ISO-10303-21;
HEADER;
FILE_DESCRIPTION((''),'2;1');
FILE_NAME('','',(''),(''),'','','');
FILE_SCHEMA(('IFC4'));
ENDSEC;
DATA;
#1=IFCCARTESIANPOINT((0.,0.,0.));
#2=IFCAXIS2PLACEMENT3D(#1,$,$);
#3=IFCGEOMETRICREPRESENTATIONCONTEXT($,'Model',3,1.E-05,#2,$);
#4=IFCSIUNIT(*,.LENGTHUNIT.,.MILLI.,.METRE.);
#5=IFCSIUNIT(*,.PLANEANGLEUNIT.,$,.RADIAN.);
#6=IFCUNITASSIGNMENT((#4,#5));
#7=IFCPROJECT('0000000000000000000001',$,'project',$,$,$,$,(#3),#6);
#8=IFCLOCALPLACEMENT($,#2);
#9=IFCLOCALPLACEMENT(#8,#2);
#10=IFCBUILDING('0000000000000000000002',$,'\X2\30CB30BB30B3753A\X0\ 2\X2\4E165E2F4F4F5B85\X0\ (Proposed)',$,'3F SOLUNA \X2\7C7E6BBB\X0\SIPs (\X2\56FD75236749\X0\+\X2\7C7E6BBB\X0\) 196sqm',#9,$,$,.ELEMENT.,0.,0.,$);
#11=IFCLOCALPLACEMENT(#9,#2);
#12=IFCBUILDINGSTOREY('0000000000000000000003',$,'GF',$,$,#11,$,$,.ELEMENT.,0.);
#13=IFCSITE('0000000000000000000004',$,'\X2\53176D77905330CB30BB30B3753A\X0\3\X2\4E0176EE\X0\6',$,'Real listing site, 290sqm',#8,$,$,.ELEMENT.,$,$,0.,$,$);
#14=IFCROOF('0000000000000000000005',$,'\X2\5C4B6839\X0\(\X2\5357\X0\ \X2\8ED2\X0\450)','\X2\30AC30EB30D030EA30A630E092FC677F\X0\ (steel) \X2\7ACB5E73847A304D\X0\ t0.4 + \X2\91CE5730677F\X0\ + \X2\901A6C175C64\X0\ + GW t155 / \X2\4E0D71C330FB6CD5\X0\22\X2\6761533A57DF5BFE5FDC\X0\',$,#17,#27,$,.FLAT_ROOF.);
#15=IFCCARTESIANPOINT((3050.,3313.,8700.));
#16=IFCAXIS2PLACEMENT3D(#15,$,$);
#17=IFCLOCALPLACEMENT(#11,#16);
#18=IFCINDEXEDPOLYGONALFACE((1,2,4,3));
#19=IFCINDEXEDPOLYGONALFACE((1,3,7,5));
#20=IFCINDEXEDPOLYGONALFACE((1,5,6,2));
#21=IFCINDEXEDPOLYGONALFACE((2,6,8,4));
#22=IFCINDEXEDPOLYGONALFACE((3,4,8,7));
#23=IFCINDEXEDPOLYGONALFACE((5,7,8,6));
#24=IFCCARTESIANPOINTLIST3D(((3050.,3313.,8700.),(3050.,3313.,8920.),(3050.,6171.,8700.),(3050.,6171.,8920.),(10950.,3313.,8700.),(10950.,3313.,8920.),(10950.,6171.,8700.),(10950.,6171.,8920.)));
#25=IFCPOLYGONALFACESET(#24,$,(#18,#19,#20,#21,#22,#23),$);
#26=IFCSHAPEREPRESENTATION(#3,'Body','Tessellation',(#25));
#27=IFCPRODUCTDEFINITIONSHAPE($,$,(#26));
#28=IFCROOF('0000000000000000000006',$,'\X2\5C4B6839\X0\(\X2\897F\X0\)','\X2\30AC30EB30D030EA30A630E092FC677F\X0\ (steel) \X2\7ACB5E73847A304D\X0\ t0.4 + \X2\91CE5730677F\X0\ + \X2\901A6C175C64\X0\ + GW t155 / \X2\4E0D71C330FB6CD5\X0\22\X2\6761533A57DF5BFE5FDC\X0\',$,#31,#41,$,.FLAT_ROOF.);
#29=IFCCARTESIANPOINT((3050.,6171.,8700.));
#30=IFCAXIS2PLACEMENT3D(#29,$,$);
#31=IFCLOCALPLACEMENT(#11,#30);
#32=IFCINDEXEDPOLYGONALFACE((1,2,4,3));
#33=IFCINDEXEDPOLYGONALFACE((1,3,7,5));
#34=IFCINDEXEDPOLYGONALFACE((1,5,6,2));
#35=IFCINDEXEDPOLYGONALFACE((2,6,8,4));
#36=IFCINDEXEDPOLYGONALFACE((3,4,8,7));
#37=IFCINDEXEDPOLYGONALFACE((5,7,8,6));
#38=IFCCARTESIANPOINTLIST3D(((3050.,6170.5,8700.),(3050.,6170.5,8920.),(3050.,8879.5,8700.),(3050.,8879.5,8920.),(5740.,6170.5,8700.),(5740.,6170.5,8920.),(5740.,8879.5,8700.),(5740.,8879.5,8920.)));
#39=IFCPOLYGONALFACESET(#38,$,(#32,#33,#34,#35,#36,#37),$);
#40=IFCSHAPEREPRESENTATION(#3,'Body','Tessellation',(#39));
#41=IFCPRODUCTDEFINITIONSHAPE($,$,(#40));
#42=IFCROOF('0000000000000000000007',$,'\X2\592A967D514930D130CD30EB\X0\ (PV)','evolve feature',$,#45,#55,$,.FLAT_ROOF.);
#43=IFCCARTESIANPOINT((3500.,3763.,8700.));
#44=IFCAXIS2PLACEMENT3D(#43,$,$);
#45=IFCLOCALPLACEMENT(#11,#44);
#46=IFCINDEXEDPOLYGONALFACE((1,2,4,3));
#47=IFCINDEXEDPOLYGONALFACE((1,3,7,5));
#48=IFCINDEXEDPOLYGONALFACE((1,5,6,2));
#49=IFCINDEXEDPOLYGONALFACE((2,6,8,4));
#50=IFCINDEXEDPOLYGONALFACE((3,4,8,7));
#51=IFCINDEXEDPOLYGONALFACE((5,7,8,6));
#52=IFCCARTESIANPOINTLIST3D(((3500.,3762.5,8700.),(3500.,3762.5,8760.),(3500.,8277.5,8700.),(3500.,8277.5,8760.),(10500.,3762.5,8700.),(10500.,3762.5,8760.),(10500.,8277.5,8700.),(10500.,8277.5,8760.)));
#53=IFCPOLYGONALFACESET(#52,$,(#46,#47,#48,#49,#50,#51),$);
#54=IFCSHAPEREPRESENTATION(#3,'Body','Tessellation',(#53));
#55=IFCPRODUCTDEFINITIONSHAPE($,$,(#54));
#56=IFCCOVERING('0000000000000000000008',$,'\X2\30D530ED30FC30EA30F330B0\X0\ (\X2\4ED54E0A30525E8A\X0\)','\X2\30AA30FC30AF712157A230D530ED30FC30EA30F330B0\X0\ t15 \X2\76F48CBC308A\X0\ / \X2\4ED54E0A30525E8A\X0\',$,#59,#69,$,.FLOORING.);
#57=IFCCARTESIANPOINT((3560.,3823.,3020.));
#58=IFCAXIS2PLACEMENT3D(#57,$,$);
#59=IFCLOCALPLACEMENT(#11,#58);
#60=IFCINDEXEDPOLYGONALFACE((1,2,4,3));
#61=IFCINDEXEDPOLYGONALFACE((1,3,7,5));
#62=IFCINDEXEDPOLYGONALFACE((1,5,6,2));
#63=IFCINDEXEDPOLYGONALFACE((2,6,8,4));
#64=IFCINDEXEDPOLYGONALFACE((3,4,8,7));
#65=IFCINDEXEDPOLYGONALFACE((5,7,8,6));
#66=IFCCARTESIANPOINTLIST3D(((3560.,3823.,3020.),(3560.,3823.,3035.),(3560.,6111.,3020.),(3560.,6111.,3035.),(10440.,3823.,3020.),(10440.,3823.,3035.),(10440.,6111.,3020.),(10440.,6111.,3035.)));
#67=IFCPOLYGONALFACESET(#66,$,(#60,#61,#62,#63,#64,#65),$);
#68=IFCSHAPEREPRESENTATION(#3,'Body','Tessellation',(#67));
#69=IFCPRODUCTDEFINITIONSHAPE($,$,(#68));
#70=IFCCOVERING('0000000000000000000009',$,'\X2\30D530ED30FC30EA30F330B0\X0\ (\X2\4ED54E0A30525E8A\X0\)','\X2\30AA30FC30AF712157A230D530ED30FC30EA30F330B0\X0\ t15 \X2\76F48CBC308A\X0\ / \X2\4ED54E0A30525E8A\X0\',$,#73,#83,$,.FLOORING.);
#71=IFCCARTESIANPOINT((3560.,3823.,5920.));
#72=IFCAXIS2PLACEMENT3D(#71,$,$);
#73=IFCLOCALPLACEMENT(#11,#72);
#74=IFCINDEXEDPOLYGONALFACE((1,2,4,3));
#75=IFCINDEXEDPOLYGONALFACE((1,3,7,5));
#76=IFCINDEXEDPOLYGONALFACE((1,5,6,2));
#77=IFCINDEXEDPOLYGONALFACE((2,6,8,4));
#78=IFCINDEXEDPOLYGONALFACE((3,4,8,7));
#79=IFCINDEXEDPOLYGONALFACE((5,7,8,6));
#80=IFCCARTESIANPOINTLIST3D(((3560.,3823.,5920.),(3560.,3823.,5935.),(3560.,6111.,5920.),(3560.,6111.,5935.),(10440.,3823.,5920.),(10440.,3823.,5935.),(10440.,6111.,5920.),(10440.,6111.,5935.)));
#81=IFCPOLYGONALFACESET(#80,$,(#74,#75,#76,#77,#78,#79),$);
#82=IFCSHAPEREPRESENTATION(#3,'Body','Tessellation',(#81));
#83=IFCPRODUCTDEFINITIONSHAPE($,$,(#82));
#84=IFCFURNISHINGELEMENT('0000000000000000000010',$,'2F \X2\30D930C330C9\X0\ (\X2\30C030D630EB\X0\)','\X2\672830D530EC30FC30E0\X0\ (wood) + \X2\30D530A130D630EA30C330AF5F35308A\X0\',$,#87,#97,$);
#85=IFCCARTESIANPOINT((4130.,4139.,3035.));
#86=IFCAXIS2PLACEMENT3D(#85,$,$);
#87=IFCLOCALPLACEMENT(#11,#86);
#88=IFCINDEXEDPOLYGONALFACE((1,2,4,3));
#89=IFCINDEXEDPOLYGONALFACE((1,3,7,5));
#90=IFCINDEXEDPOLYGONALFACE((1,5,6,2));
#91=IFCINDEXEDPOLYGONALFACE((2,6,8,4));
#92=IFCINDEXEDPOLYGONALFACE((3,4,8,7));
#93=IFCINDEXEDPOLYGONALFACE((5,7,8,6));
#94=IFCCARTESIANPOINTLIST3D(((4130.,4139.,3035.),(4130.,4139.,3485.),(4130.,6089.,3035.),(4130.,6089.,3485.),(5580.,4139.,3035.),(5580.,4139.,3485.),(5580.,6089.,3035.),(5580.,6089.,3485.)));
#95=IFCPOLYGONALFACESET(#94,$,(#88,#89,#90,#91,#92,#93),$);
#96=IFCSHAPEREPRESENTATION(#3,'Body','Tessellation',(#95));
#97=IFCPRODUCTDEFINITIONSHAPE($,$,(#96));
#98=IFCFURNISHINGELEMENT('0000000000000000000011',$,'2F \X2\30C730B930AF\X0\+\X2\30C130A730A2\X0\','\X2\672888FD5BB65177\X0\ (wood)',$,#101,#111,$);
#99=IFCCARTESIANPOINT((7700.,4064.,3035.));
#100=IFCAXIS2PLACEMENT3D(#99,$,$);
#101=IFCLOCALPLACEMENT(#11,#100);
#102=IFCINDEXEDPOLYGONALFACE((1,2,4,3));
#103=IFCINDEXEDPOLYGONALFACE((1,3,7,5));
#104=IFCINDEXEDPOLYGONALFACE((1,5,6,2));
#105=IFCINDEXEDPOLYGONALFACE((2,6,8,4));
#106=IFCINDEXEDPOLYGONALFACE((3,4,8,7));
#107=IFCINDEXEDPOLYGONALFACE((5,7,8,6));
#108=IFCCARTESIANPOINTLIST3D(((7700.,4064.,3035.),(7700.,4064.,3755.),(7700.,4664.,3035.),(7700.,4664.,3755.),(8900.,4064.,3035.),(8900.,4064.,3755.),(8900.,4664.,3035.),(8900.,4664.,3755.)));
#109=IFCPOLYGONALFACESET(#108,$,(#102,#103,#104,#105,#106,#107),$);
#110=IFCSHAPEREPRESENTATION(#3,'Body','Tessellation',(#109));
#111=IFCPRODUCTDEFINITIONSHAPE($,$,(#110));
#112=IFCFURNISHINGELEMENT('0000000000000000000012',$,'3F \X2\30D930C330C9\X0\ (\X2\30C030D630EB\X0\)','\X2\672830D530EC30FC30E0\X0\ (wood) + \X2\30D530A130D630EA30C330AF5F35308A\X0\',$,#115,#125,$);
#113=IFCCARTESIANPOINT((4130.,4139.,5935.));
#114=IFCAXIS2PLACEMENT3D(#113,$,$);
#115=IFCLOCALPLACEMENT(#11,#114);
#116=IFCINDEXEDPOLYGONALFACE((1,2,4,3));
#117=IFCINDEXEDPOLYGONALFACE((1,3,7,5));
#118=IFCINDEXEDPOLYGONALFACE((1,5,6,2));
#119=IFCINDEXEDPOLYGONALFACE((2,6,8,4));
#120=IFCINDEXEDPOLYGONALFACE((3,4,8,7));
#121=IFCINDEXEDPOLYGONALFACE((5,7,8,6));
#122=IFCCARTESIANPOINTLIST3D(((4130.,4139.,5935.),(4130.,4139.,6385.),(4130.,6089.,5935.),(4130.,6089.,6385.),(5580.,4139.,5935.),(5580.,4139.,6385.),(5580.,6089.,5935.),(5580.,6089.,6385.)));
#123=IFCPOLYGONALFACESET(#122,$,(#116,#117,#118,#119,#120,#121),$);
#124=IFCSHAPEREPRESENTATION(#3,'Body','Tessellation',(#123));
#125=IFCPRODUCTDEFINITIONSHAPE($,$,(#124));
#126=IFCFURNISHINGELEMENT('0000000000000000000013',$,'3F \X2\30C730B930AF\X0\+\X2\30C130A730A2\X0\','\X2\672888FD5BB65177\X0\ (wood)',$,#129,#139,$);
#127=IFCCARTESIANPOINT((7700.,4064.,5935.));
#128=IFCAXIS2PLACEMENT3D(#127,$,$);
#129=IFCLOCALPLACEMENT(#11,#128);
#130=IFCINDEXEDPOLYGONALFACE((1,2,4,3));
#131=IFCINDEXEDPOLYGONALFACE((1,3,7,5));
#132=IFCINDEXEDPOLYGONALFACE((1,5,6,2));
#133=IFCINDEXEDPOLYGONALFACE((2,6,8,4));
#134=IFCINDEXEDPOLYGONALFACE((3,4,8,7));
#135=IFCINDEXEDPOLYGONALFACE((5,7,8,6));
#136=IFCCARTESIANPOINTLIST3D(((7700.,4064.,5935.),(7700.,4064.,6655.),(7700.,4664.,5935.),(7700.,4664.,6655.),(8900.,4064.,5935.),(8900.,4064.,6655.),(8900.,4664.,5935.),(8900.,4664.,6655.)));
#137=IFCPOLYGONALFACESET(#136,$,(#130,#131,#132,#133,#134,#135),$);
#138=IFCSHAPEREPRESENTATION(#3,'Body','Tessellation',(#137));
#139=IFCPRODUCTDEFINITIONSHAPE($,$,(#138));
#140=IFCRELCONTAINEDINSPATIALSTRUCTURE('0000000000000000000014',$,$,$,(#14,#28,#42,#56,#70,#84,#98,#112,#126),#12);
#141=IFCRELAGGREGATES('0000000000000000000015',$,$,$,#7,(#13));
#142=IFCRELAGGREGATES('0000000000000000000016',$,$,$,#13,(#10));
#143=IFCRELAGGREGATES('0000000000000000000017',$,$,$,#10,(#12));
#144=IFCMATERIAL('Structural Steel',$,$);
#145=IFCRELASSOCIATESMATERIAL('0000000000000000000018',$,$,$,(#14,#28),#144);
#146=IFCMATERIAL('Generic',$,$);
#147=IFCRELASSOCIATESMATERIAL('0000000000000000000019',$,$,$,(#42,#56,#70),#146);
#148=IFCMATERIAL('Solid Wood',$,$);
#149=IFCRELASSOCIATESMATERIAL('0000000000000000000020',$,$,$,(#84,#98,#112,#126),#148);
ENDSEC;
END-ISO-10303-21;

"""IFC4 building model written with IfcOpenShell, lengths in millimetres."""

from ifc_helpers import new_model, si_unit, frame, frame_2d, origin, place, context, project, spatial, rectangle, extrude, material, element, save


model = new_model("IFC4")

# Units and contexts
model_context = context("Model", 3, precision=1e-05, world=origin())
ifc_project = project(units=[si_unit("LENGTHUNIT", "METRE", prefix="MILLI"), si_unit("PLANEANGLEUNIT", "RADIAN")], contexts=[model_context])

# Site, building, storey
site_placement = place(None, origin())
site = spatial("IfcSite", under=ifc_project, at=site_placement, Name="北海道ニセコ町3丁目6", ObjectType="Real listing site, 290sqm", CompositionType="ELEMENT", RefElevation=0.0)
building_placement = place(site_placement, origin())
building = spatial("IfcBuilding", under=site, at=building_placement, Name="ニセコ町 2世帯住宅 (Proposed)", ObjectType="3F SOLUNA 籾殻SIPs (国産杉+籾殻) 196sqm", CompositionType="ELEMENT", ElevationOfRefHeight=0.0, ElevationOfTerrain=0.0)
storey_placement = place(building_placement, origin())
storey = spatial("IfcBuildingStorey", under=building, at=storey_placement, Name="GF", CompositionType="ELEMENT", Elevation=0.0)

# Shared definitions
ifc_material_1 = material(Name="Solid Wood")

# Roofs
ifc_material_2 = material(Name="Structural Steel")
roof_1_placement = place(storey_placement, frame((3050.0, 3313.0, 8700.0)))
element("IfcRoof", 1, at=roof_1_placement, inside=storey, material=ifc_material_2, Name="屋根(南 軒450)", Description="ガルバリウム鋼板 (steel) 立平葺き t0.4 + 野地板 + 通気層 + GW t155 / 不燃・法22条区域対応", PredefinedType="FLAT_ROOF", context=model_context, shape_type="SweptSolid", body=[
    extrude(rectangle(XDim=7900.0, YDim=2858.0, at=frame_2d((3950.0, 1429.0))), frame((3050.0, 3313.0, 8700.0)), (0.0, 0.0, 1.0), 220.0),
])
roof_2_placement = place(storey_placement, frame((3050.0, 6171.0, 8700.0)))
element("IfcRoof", 2, at=roof_2_placement, inside=storey, material=ifc_material_2, Name="屋根(西)", Description="ガルバリウム鋼板 (steel) 立平葺き t0.4 + 野地板 + 通気層 + GW t155 / 不燃・法22条区域対応", PredefinedType="FLAT_ROOF", context=model_context, shape_type="SweptSolid", body=[
    extrude(rectangle(XDim=2690.0, YDim=2709.0, at=frame_2d((1345.0, 1354.0))), frame((3050.0, 6171.0, 8700.0)), (0.0, 0.0, 1.0), 220.0),
])
ifc_material_3 = material(Name="Generic")
roof_3_placement = place(storey_placement, frame((3500.0, 3763.0, 8700.0)))
element("IfcRoof", 3, at=roof_3_placement, inside=storey, material=ifc_material_3, Name="太陽光パネル (PV)", Description="evolve feature", PredefinedType="FLAT_ROOF", context=model_context, shape_type="SweptSolid", body=[
    extrude(rectangle(XDim=7000.0, YDim=4515.0, at=frame_2d((3500.0, 2257.0))), frame((3500.0, 3763.0, 8700.0)), (0.0, 0.0, 1.0), 60.0),
])

# Coverings
covering_1_placement = place(storey_placement, frame((3560.0, 3823.0, 3020.0)))
element("IfcCovering", 4, at=covering_1_placement, inside=storey, material=ifc_material_3, Name="フローリング (仕上げ床)", Description="オーク無垢フローリング t15 直貼り / 仕上げ床", PredefinedType="FLOORING", context=model_context, shape_type="SweptSolid", body=[
    extrude(rectangle(XDim=6880.0, YDim=2288.0, at=frame_2d((3440.0, 1144.0))), frame((3560.0, 3823.0, 3020.0)), (0.0, 0.0, 1.0), 15.0),
])
covering_2_placement = place(storey_placement, frame((3560.0, 3823.0, 5920.0)))
element("IfcCovering", 5, at=covering_2_placement, inside=storey, material=ifc_material_3, Name="フローリング (仕上げ床)", Description="オーク無垢フローリング t15 直貼り / 仕上げ床", PredefinedType="FLOORING", context=model_context, shape_type="SweptSolid", body=[
    extrude(rectangle(XDim=6880.0, YDim=2288.0, at=frame_2d((3440.0, 1144.0))), frame((3560.0, 3823.0, 5920.0)), (0.0, 0.0, 1.0), 15.0),
])

# Furnishing elements
furnishing_1_placement = place(storey_placement, frame((4130.0, 4139.0, 3035.0)))
element("IfcFurnishingElement", 6, at=furnishing_1_placement, inside=storey, material=ifc_material_1, Name="2F ベッド (ダブル)", Description="木フレーム (wood) + ファブリック張り", context=model_context, shape_type="SweptSolid", body=[
    extrude(rectangle(XDim=1450.0, YDim=1950.0, at=frame_2d((725.0, 975.0))), frame((4130.0, 4139.0, 3035.0)), (0.0, 0.0, 1.0), 450.0),
])
furnishing_2_placement = place(storey_placement, frame((7700.0, 4064.0, 3035.0)))
element("IfcFurnishingElement", 7, at=furnishing_2_placement, inside=storey, material=ifc_material_1, Name="2F デスク+チェア", Description="木製家具 (wood)", context=model_context, shape_type="SweptSolid", body=[
    extrude(rectangle(XDim=1200.0, YDim=600.0, at=frame_2d((600.0, 300.0))), frame((7700.0, 4064.0, 3035.0)), (0.0, 0.0, 1.0), 720.0),
])
furnishing_3_placement = place(storey_placement, frame((4130.0, 4139.0, 5935.0)))
element("IfcFurnishingElement", 8, at=furnishing_3_placement, inside=storey, material=ifc_material_1, Name="3F ベッド (ダブル)", Description="木フレーム (wood) + ファブリック張り", context=model_context, shape_type="SweptSolid", body=[
    extrude(rectangle(XDim=1450.0, YDim=1950.0, at=frame_2d((725.0, 975.0))), frame((4130.0, 4139.0, 5935.0)), (0.0, 0.0, 1.0), 450.0),
])
furnishing_4_placement = place(storey_placement, frame((7700.0, 4064.0, 5935.0)))
element("IfcFurnishingElement", 9, at=furnishing_4_placement, inside=storey, material=ifc_material_1, Name="3F デスク+チェア", Description="木製家具 (wood)", context=model_context, shape_type="SweptSolid", body=[
    extrude(rectangle(XDim=1200.0, YDim=600.0, at=frame_2d((600.0, 300.0))), frame((7700.0, 4064.0, 5935.0)), (0.0, 0.0, 1.0), 720.0),
])

save(model, "model.ifc")
